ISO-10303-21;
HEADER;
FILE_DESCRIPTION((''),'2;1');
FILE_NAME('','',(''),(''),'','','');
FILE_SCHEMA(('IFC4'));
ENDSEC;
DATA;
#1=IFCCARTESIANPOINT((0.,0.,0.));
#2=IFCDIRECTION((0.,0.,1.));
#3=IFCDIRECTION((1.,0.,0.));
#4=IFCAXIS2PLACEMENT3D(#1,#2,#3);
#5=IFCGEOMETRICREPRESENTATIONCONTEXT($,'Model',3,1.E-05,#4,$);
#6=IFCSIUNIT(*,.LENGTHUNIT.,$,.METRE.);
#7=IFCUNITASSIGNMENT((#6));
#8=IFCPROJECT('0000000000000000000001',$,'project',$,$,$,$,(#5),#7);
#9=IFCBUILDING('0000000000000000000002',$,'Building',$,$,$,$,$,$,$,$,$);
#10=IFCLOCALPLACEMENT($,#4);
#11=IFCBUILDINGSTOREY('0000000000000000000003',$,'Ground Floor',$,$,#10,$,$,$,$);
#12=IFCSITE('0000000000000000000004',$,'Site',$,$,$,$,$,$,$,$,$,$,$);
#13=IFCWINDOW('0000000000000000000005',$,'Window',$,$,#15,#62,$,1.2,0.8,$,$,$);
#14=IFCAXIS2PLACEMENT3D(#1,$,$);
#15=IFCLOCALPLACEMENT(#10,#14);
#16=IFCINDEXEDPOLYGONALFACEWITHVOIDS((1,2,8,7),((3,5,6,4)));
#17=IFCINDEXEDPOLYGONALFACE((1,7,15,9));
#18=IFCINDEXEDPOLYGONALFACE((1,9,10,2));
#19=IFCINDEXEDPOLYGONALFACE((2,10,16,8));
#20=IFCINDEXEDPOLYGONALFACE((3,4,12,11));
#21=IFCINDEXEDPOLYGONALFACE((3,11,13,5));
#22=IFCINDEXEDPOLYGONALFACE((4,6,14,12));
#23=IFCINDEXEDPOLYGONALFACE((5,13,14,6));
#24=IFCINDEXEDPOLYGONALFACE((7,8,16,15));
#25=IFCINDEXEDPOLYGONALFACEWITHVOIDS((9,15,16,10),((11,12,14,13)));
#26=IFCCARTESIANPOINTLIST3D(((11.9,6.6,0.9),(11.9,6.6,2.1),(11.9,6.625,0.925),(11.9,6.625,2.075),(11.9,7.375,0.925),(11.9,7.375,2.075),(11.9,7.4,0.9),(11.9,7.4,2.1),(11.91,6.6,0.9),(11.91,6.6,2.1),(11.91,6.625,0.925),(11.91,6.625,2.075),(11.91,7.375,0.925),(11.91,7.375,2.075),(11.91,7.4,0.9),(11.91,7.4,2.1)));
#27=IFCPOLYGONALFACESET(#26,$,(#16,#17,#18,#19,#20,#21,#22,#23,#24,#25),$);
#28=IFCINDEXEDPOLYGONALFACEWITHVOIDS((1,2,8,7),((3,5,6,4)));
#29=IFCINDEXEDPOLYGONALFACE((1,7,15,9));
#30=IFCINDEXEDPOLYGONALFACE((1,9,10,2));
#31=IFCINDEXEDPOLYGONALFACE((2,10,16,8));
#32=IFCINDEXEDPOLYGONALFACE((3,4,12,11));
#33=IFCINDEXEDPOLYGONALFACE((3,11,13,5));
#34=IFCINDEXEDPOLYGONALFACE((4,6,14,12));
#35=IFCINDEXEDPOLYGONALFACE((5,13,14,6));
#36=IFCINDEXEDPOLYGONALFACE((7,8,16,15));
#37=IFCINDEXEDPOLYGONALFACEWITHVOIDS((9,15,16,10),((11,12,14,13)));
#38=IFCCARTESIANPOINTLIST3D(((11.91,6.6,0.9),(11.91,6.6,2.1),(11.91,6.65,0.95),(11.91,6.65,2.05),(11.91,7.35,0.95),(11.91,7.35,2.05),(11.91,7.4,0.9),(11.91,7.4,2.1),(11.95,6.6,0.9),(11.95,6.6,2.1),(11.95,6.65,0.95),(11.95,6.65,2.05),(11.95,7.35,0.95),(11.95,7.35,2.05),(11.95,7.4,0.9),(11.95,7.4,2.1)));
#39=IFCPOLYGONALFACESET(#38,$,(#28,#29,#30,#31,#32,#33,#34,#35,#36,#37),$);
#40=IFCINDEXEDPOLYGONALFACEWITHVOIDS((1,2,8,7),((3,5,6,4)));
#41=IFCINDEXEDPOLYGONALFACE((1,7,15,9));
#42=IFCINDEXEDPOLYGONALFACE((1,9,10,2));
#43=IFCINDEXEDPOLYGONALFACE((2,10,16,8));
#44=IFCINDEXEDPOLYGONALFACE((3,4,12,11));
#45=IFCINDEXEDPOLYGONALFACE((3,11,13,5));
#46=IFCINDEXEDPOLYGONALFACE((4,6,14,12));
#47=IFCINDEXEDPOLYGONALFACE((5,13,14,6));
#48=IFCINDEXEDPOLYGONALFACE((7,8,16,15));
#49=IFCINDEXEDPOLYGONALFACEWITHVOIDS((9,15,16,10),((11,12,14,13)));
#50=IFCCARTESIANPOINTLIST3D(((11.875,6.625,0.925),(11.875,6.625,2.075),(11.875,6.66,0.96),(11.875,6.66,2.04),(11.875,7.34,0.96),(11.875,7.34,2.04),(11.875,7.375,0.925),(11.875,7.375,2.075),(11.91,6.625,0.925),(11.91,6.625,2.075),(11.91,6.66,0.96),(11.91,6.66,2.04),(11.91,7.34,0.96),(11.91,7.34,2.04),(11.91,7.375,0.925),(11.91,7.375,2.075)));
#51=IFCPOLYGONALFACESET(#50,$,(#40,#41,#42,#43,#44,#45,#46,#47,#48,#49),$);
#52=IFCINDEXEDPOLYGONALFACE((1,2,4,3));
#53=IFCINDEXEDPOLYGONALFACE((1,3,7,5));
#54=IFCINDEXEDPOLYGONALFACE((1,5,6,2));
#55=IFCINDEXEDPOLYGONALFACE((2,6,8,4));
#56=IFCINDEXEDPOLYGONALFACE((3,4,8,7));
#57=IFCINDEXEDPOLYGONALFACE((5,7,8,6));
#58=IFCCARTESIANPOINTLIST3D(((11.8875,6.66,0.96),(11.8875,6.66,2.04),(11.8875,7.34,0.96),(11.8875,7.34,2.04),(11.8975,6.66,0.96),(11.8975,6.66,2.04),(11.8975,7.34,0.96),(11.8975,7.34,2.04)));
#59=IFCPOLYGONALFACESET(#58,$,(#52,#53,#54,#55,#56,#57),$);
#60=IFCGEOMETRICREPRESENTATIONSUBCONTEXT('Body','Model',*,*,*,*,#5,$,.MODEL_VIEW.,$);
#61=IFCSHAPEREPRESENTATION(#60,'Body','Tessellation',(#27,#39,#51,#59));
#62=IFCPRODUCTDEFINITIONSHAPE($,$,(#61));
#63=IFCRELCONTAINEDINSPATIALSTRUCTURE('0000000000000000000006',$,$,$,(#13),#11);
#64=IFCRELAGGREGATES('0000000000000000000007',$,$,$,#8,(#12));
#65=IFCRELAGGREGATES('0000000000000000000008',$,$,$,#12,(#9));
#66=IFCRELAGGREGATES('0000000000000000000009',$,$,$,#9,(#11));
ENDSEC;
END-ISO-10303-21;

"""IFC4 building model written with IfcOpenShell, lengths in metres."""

from ifc_helpers import new_model, si_unit, frame, origin_with_axes, place, context, subcontext, project, spatial, line, indexed_curve, outline, extrude, element, save


model = new_model("IFC4")

# Units and contexts
model_context = context("Model", 3, precision=1e-05, world=origin_with_axes())
body_context = subcontext(model_context, "Body", "Model", "MODEL_VIEW")
ifc_project = project(units=[si_unit("LENGTHUNIT", "METRE")], contexts=[model_context])

# Site, building, storey
site = spatial("IfcSite", under=ifc_project, Name="Site")
building = spatial("IfcBuilding", under=site, Name="Building")
storey_placement = place(None, origin_with_axes())
storey = spatial("IfcBuildingStorey", under=building, at=storey_placement, Name="Ground Floor")

# Window
window_1_placement = place(storey_placement, frame((12.0, 6.6, 0.9), z_axis=(0.0, 0.0, 1.0), x_axis=(0.0, 1.0, 0.0)))
element("IfcWindow", 1, at=window_1_placement, inside=storey, Name="Window", OverallHeight=1.2, OverallWidth=0.8, context=body_context, shape_type="SweptSolid", body=[
    extrude(outline(indexed_curve([(0.0, 0.0), (0.8, 0.0), (0.8, 1.2), (0.0, 1.2)], segments=[line(1, 2, 3, 4, 1)]), holes=[indexed_curve([(0.025, 0.025), (0.775, 0.025), (0.775, 1.175), (0.025, 1.175)], segments=[line(1, 2, 3, 4, 1)])]), frame((0.0, 0.09, 0.0), z_axis=(0.0, -1.0, 0.0), x_axis=(1.0, 0.0, 0.0)), (0.0, 0.0, -1.0), 0.01),
    extrude(outline(indexed_curve([(0.0, 0.0), (0.8, 0.0), (0.8, 1.2), (0.0, 1.2)], segments=[line(1, 2, 3, 4, 1)]), holes=[indexed_curve([(0.05, 0.05), (0.75, 0.05), (0.75, 1.15), (0.05, 1.15)], segments=[line(1, 2, 3, 4, 1)])]), frame((0.0, 0.05, 0.0), z_axis=(0.0, -1.0, 0.0), x_axis=(1.0, 0.0, 0.0)), (0.0, 0.0, -1.0), 0.04),
    extrude(outline(indexed_curve([(0.0, 0.0), (0.75, 0.0), (0.75, 1.15), (0.0, 1.15)], segments=[line(1, 2, 3, 4, 1)]), holes=[indexed_curve([(0.035, 0.035), (0.715, 0.035), (0.715, 1.115), (0.035, 1.115)], segments=[line(1, 2, 3, 4, 1)])]), frame((0.025, 0.09, 0.025), z_axis=(0.0, -1.0, 0.0), x_axis=(1.0, 0.0, 0.0)), (0.0, 0.0, -1.0), 0.035),
    extrude(outline(indexed_curve([(0.035, 0.035), (0.715, 0.035), (0.715, 1.115), (0.035, 1.115)], segments=[line(1, 2, 3, 4, 1)])), frame((0.025, 0.1025, 0.025), z_axis=(0.0, -1.0, 0.0), x_axis=(1.0, 0.0, 0.0)), (0.0, 0.0, -1.0), 0.01),
])

save(model, "model.ifc")
